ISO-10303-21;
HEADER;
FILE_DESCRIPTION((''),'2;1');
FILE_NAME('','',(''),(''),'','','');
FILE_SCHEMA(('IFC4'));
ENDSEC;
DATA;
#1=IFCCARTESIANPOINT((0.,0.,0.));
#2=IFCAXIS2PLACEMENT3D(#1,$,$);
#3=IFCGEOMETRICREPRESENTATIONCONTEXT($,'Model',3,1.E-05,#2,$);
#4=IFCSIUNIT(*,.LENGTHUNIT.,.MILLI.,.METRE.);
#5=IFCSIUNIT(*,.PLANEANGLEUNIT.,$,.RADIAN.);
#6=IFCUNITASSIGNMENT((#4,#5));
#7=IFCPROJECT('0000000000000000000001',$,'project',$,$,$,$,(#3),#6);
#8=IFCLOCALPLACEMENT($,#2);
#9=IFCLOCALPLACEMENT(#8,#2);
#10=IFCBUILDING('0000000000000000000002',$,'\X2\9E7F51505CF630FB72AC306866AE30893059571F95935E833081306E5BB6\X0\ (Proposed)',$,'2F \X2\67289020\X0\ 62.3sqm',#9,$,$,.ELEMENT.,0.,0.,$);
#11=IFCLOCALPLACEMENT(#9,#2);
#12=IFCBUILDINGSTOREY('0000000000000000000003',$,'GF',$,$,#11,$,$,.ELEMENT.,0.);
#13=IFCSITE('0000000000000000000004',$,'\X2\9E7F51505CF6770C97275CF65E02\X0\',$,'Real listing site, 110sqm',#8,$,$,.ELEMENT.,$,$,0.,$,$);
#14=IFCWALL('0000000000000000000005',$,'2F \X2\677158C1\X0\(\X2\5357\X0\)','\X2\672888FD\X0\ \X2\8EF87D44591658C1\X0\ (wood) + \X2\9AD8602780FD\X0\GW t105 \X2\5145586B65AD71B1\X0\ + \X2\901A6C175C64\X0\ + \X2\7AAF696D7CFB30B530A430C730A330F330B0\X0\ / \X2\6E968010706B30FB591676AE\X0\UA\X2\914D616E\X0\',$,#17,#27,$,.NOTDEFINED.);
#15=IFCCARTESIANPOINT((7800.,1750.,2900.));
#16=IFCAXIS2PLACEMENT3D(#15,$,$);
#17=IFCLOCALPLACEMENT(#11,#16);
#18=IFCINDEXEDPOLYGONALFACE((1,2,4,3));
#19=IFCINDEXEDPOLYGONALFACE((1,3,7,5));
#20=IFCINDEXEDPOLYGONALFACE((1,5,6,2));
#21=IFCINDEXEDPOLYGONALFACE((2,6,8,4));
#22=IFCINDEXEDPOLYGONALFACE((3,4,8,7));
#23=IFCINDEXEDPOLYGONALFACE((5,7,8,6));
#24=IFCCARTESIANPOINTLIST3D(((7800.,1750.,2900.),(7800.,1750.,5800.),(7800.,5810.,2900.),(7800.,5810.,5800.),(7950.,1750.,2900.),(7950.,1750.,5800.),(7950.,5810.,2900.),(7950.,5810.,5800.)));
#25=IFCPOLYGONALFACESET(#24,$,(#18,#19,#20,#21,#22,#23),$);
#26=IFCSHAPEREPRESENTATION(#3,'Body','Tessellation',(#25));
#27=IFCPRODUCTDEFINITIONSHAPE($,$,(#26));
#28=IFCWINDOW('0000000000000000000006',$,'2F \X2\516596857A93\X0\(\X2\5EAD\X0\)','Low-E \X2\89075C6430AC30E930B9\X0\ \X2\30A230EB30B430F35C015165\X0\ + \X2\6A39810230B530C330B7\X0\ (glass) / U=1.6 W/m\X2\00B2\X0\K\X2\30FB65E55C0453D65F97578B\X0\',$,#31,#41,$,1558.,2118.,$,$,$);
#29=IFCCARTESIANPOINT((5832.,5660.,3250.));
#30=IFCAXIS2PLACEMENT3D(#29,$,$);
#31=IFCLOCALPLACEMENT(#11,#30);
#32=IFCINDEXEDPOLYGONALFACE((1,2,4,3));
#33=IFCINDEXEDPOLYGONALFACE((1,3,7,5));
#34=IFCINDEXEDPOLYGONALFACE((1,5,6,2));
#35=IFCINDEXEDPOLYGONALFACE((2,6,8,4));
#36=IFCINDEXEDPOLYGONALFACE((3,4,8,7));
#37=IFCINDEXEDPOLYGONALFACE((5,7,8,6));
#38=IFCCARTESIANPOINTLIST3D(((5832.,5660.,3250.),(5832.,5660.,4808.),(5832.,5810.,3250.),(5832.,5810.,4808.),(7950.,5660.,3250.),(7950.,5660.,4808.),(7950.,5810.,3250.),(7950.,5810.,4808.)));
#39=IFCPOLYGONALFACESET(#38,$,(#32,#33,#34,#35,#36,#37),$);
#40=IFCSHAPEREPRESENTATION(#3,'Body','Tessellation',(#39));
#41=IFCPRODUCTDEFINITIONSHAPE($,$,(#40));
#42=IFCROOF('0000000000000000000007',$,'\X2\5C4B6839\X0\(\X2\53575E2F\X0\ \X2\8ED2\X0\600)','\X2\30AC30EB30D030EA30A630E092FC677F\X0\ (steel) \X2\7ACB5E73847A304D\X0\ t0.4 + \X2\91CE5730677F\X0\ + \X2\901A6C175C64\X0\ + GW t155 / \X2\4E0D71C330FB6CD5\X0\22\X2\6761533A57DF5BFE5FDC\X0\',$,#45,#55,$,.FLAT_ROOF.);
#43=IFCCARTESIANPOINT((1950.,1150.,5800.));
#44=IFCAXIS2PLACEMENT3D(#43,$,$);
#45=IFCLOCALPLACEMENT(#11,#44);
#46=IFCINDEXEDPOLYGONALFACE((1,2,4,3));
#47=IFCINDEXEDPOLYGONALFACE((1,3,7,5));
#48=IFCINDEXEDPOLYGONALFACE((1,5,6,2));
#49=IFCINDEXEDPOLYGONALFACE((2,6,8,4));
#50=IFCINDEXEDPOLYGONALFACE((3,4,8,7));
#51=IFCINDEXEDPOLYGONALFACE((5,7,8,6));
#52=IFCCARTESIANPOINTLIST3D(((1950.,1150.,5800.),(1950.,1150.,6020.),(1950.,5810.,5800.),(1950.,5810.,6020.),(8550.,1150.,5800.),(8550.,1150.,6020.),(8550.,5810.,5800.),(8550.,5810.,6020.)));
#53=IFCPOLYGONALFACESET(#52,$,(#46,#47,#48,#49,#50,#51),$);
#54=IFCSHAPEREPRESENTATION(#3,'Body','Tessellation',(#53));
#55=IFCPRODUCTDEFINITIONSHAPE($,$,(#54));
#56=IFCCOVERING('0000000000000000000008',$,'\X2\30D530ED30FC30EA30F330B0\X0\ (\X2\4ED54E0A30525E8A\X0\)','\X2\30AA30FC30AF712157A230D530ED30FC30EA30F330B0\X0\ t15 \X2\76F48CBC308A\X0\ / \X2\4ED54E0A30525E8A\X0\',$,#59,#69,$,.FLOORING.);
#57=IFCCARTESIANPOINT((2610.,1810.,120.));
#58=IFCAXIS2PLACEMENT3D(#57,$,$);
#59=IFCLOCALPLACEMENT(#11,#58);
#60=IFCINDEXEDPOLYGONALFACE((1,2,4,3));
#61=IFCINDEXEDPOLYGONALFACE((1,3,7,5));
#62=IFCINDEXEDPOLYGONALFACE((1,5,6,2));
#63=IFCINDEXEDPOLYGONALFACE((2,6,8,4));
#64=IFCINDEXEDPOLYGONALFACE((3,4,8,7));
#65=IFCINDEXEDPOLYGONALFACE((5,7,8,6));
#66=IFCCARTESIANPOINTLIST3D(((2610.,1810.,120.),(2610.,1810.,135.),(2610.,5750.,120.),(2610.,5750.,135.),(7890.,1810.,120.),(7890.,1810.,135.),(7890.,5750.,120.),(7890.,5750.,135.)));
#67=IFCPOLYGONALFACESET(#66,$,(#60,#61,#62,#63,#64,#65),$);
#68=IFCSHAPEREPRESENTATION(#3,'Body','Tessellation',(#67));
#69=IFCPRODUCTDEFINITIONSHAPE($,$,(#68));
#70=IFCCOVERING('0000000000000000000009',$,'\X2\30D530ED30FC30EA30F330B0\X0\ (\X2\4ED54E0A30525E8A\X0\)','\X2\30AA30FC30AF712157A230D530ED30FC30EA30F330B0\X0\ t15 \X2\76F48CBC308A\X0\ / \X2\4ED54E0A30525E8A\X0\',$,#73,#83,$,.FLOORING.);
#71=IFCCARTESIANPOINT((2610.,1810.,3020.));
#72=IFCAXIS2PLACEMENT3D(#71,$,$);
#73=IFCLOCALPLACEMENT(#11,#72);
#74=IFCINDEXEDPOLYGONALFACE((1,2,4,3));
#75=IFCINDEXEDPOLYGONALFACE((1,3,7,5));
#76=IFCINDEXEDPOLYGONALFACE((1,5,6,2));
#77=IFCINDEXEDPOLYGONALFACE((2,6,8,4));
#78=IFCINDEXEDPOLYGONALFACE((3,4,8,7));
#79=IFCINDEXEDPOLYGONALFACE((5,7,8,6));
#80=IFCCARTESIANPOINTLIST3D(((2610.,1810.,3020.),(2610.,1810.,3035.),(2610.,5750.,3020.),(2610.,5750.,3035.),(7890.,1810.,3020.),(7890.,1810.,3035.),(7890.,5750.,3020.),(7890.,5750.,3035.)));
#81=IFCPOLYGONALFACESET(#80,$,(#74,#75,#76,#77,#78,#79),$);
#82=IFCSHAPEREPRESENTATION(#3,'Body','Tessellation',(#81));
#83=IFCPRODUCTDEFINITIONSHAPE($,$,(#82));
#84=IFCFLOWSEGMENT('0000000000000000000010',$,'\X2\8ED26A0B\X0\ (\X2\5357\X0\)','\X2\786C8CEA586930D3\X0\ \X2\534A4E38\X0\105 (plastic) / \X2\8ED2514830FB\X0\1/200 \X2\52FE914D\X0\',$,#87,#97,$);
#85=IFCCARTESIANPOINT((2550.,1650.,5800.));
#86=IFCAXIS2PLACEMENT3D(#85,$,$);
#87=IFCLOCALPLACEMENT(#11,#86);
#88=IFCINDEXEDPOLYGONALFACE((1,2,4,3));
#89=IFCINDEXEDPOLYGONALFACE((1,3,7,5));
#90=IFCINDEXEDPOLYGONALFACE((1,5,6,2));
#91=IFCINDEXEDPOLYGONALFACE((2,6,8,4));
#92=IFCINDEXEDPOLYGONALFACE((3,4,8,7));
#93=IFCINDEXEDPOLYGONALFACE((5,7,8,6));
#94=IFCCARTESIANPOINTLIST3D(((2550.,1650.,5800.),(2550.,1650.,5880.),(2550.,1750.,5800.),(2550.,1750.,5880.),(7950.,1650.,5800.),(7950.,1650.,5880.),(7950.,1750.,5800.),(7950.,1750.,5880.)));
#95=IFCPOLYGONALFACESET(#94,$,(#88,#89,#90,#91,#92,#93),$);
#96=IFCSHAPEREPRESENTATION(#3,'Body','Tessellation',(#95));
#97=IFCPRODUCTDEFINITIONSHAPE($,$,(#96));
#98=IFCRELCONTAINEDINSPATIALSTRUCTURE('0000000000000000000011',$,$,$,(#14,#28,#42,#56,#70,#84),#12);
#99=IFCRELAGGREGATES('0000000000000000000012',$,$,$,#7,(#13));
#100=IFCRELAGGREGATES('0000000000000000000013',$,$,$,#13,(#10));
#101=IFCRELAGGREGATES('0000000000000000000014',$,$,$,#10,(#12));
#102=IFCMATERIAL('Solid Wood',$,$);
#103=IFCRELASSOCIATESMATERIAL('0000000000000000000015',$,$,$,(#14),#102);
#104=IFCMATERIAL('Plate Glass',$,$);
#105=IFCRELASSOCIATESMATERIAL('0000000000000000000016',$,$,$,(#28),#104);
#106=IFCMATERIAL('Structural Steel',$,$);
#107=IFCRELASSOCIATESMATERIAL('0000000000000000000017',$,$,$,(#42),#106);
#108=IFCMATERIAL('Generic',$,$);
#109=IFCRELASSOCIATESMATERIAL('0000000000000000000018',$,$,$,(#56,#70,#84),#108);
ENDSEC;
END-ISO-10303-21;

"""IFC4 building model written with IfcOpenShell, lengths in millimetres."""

from ifc_helpers import new_model, si_unit, frame, frame_2d, origin, place, context, project, spatial, rectangle, extrude, material, element, fill, save


model = new_model("IFC4")

# Units and contexts
model_context = context("Model", 3, precision=1e-05, world=origin())
ifc_project = project(units=[si_unit("LENGTHUNIT", "METRE", prefix="MILLI"), si_unit("PLANEANGLEUNIT", "RADIAN")], contexts=[model_context])

# Site, building, storey
site_placement = place(None, origin())
site = spatial("IfcSite", under=ifc_project, at=site_placement, Name="鹿児島県霧島市", ObjectType="Real listing site, 110sqm", CompositionType="ELEMENT", RefElevation=0.0)
building_placement = place(site_placement, origin())
building = spatial("IfcBuilding", under=site, at=building_placement, Name="鹿児島・犬と暮らす土間広めの家 (Proposed)", ObjectType="2F 木造 62.3sqm", CompositionType="ELEMENT", ElevationOfRefHeight=0.0, ElevationOfTerrain=0.0)
storey_placement = place(building_placement, origin())
storey = spatial("IfcBuildingStorey", under=building, at=storey_placement, Name="GF", CompositionType="ELEMENT", Elevation=0.0)

# Shared definitions
ifc_material_1 = material(Name="Solid Wood")

# Wall, opening, window
ifc_material_2 = material(Name="Plate Glass")
wall_1_placement = place(storey_placement, frame((7800.0, 1750.0, 2900.0)))
wall_1 = element("IfcWall", 1, at=wall_1_placement, inside=storey, material=ifc_material_1, Name="2F 東壁(南)", Description="木製 軸組外壁 (wood) + 高性能GW t105 充填断熱 + 通気層 + 窯業系サイディング / 準耐火・外皮UA配慮", PredefinedType="NOTDEFINED", context=model_context, shape_type="SweptSolid", body=[
    extrude(rectangle(XDim=150.0, YDim=4060.0, at=frame_2d((75.0, 2030.0))), frame((7800.0, 1750.0, 2900.0)), (0.0, 0.0, 1.0), 2900.0),
])
opening_1_placement = place(storey_placement, frame((5832.0, 5660.0, 3250.0)))
opening_1 = element("IfcOpeningElement", 2, at=opening_1_placement, cuts=wall_1, PredefinedType="NOTDEFINED", context=model_context, shape_type="SweptSolid", body=[
    extrude(rectangle(XDim=2118.0, YDim=150.0, at=frame_2d((1059.0, 75.0))), frame((5832.0, 5660.0, 3250.0)), (0.0, 0.0, 1.0), 1558.0),
])
window_1_placement = place(storey_placement, frame((5832.0, 5660.0, 3250.0)))
window_1 = element("IfcWindow", 3, at=window_1_placement, inside=storey, material=ifc_material_2, Name="2F 入隅窓(庭)", Description="Low-E 複層ガラス アルゴン封入 + 樹脂サッシ (glass) / U=1.6 W/m²K・日射取得型", OverallHeight=1558.0, OverallWidth=2118.0, context=model_context, shape_type="SweptSolid", body=[
    extrude(rectangle(XDim=2118.0, YDim=150.0, at=frame_2d((1059.0, 75.0))), frame((5832.0, 5660.0, 3250.0)), (0.0, 0.0, 1.0), 1558.0),
])
fill(opening_1, window_1)

# Roof
ifc_material_3 = material(Name="Structural Steel")
for number, where, name in (
    (4, (1950.0, 1150.0, 5800.0), "屋根(南帯 軒600)"),
):
    element("IfcRoof", number, at=place(storey_placement, frame(where)), inside=storey, material=ifc_material_3, Name=name, Description="ガルバリウム鋼板 (steel) 立平葺き t0.4 + 野地板 + 通気層 + GW t155 / 不燃・法22条区域対応", PredefinedType="FLAT_ROOF", context=model_context, shape_type="SweptSolid", body=[
        extrude(rectangle(XDim=6600.0, YDim=4660.0, at=frame_2d((3300.0, 2330.0))), frame((1950.0, 1150.0, 5800.0)), (0.0, 0.0, 1.0), 220.0),
    ])

# Coverings
ifc_material_4 = material(Name="Generic")
covering_1_placement = place(storey_placement, frame((2610.0, 1810.0, 120.0)))
element("IfcCovering", 5, at=covering_1_placement, inside=storey, material=ifc_material_4, Name="フローリング (仕上げ床)", Description="オーク無垢フローリング t15 直貼り / 仕上げ床", PredefinedType="FLOORING", context=model_context, shape_type="SweptSolid", body=[
    extrude(rectangle(XDim=5280.0, YDim=3940.0, at=frame_2d((2640.0, 1970.0))), frame((2610.0, 1810.0, 120.0)), (0.0, 0.0, 1.0), 15.0),
])
covering_2_placement = place(storey_placement, frame((2610.0, 1810.0, 3020.0)))
element("IfcCovering", 6, at=covering_2_placement, inside=storey, material=ifc_material_4, Name="フローリング (仕上げ床)", Description="オーク無垢フローリング t15 直貼り / 仕上げ床", PredefinedType="FLOORING", context=model_context, shape_type="SweptSolid", body=[
    extrude(rectangle(XDim=5280.0, YDim=3940.0, at=frame_2d((2640.0, 1970.0))), frame((2610.0, 1810.0, 3020.0)), (0.0, 0.0, 1.0), 15.0),
])

# Flow segment
flow_segment_placement = place(storey_placement, frame((2550.0, 1650.0, 5800.0)))
element("IfcFlowSegment", 7, at=flow_segment_placement, inside=storey, material=ifc_material_4, Name="軒樋 (南)", Description="硬質塩ビ 半丸105 (plastic) / 軒先・1/200 勾配", context=model_context, shape_type="SweptSolid", body=[
    extrude(rectangle(XDim=5400.0, YDim=100.0, at=frame_2d((2700.0, 50.0))), frame((2550.0, 1650.0, 5800.0)), (0.0, 0.0, 1.0), 80.0),
])

save(model, "model.ifc")
